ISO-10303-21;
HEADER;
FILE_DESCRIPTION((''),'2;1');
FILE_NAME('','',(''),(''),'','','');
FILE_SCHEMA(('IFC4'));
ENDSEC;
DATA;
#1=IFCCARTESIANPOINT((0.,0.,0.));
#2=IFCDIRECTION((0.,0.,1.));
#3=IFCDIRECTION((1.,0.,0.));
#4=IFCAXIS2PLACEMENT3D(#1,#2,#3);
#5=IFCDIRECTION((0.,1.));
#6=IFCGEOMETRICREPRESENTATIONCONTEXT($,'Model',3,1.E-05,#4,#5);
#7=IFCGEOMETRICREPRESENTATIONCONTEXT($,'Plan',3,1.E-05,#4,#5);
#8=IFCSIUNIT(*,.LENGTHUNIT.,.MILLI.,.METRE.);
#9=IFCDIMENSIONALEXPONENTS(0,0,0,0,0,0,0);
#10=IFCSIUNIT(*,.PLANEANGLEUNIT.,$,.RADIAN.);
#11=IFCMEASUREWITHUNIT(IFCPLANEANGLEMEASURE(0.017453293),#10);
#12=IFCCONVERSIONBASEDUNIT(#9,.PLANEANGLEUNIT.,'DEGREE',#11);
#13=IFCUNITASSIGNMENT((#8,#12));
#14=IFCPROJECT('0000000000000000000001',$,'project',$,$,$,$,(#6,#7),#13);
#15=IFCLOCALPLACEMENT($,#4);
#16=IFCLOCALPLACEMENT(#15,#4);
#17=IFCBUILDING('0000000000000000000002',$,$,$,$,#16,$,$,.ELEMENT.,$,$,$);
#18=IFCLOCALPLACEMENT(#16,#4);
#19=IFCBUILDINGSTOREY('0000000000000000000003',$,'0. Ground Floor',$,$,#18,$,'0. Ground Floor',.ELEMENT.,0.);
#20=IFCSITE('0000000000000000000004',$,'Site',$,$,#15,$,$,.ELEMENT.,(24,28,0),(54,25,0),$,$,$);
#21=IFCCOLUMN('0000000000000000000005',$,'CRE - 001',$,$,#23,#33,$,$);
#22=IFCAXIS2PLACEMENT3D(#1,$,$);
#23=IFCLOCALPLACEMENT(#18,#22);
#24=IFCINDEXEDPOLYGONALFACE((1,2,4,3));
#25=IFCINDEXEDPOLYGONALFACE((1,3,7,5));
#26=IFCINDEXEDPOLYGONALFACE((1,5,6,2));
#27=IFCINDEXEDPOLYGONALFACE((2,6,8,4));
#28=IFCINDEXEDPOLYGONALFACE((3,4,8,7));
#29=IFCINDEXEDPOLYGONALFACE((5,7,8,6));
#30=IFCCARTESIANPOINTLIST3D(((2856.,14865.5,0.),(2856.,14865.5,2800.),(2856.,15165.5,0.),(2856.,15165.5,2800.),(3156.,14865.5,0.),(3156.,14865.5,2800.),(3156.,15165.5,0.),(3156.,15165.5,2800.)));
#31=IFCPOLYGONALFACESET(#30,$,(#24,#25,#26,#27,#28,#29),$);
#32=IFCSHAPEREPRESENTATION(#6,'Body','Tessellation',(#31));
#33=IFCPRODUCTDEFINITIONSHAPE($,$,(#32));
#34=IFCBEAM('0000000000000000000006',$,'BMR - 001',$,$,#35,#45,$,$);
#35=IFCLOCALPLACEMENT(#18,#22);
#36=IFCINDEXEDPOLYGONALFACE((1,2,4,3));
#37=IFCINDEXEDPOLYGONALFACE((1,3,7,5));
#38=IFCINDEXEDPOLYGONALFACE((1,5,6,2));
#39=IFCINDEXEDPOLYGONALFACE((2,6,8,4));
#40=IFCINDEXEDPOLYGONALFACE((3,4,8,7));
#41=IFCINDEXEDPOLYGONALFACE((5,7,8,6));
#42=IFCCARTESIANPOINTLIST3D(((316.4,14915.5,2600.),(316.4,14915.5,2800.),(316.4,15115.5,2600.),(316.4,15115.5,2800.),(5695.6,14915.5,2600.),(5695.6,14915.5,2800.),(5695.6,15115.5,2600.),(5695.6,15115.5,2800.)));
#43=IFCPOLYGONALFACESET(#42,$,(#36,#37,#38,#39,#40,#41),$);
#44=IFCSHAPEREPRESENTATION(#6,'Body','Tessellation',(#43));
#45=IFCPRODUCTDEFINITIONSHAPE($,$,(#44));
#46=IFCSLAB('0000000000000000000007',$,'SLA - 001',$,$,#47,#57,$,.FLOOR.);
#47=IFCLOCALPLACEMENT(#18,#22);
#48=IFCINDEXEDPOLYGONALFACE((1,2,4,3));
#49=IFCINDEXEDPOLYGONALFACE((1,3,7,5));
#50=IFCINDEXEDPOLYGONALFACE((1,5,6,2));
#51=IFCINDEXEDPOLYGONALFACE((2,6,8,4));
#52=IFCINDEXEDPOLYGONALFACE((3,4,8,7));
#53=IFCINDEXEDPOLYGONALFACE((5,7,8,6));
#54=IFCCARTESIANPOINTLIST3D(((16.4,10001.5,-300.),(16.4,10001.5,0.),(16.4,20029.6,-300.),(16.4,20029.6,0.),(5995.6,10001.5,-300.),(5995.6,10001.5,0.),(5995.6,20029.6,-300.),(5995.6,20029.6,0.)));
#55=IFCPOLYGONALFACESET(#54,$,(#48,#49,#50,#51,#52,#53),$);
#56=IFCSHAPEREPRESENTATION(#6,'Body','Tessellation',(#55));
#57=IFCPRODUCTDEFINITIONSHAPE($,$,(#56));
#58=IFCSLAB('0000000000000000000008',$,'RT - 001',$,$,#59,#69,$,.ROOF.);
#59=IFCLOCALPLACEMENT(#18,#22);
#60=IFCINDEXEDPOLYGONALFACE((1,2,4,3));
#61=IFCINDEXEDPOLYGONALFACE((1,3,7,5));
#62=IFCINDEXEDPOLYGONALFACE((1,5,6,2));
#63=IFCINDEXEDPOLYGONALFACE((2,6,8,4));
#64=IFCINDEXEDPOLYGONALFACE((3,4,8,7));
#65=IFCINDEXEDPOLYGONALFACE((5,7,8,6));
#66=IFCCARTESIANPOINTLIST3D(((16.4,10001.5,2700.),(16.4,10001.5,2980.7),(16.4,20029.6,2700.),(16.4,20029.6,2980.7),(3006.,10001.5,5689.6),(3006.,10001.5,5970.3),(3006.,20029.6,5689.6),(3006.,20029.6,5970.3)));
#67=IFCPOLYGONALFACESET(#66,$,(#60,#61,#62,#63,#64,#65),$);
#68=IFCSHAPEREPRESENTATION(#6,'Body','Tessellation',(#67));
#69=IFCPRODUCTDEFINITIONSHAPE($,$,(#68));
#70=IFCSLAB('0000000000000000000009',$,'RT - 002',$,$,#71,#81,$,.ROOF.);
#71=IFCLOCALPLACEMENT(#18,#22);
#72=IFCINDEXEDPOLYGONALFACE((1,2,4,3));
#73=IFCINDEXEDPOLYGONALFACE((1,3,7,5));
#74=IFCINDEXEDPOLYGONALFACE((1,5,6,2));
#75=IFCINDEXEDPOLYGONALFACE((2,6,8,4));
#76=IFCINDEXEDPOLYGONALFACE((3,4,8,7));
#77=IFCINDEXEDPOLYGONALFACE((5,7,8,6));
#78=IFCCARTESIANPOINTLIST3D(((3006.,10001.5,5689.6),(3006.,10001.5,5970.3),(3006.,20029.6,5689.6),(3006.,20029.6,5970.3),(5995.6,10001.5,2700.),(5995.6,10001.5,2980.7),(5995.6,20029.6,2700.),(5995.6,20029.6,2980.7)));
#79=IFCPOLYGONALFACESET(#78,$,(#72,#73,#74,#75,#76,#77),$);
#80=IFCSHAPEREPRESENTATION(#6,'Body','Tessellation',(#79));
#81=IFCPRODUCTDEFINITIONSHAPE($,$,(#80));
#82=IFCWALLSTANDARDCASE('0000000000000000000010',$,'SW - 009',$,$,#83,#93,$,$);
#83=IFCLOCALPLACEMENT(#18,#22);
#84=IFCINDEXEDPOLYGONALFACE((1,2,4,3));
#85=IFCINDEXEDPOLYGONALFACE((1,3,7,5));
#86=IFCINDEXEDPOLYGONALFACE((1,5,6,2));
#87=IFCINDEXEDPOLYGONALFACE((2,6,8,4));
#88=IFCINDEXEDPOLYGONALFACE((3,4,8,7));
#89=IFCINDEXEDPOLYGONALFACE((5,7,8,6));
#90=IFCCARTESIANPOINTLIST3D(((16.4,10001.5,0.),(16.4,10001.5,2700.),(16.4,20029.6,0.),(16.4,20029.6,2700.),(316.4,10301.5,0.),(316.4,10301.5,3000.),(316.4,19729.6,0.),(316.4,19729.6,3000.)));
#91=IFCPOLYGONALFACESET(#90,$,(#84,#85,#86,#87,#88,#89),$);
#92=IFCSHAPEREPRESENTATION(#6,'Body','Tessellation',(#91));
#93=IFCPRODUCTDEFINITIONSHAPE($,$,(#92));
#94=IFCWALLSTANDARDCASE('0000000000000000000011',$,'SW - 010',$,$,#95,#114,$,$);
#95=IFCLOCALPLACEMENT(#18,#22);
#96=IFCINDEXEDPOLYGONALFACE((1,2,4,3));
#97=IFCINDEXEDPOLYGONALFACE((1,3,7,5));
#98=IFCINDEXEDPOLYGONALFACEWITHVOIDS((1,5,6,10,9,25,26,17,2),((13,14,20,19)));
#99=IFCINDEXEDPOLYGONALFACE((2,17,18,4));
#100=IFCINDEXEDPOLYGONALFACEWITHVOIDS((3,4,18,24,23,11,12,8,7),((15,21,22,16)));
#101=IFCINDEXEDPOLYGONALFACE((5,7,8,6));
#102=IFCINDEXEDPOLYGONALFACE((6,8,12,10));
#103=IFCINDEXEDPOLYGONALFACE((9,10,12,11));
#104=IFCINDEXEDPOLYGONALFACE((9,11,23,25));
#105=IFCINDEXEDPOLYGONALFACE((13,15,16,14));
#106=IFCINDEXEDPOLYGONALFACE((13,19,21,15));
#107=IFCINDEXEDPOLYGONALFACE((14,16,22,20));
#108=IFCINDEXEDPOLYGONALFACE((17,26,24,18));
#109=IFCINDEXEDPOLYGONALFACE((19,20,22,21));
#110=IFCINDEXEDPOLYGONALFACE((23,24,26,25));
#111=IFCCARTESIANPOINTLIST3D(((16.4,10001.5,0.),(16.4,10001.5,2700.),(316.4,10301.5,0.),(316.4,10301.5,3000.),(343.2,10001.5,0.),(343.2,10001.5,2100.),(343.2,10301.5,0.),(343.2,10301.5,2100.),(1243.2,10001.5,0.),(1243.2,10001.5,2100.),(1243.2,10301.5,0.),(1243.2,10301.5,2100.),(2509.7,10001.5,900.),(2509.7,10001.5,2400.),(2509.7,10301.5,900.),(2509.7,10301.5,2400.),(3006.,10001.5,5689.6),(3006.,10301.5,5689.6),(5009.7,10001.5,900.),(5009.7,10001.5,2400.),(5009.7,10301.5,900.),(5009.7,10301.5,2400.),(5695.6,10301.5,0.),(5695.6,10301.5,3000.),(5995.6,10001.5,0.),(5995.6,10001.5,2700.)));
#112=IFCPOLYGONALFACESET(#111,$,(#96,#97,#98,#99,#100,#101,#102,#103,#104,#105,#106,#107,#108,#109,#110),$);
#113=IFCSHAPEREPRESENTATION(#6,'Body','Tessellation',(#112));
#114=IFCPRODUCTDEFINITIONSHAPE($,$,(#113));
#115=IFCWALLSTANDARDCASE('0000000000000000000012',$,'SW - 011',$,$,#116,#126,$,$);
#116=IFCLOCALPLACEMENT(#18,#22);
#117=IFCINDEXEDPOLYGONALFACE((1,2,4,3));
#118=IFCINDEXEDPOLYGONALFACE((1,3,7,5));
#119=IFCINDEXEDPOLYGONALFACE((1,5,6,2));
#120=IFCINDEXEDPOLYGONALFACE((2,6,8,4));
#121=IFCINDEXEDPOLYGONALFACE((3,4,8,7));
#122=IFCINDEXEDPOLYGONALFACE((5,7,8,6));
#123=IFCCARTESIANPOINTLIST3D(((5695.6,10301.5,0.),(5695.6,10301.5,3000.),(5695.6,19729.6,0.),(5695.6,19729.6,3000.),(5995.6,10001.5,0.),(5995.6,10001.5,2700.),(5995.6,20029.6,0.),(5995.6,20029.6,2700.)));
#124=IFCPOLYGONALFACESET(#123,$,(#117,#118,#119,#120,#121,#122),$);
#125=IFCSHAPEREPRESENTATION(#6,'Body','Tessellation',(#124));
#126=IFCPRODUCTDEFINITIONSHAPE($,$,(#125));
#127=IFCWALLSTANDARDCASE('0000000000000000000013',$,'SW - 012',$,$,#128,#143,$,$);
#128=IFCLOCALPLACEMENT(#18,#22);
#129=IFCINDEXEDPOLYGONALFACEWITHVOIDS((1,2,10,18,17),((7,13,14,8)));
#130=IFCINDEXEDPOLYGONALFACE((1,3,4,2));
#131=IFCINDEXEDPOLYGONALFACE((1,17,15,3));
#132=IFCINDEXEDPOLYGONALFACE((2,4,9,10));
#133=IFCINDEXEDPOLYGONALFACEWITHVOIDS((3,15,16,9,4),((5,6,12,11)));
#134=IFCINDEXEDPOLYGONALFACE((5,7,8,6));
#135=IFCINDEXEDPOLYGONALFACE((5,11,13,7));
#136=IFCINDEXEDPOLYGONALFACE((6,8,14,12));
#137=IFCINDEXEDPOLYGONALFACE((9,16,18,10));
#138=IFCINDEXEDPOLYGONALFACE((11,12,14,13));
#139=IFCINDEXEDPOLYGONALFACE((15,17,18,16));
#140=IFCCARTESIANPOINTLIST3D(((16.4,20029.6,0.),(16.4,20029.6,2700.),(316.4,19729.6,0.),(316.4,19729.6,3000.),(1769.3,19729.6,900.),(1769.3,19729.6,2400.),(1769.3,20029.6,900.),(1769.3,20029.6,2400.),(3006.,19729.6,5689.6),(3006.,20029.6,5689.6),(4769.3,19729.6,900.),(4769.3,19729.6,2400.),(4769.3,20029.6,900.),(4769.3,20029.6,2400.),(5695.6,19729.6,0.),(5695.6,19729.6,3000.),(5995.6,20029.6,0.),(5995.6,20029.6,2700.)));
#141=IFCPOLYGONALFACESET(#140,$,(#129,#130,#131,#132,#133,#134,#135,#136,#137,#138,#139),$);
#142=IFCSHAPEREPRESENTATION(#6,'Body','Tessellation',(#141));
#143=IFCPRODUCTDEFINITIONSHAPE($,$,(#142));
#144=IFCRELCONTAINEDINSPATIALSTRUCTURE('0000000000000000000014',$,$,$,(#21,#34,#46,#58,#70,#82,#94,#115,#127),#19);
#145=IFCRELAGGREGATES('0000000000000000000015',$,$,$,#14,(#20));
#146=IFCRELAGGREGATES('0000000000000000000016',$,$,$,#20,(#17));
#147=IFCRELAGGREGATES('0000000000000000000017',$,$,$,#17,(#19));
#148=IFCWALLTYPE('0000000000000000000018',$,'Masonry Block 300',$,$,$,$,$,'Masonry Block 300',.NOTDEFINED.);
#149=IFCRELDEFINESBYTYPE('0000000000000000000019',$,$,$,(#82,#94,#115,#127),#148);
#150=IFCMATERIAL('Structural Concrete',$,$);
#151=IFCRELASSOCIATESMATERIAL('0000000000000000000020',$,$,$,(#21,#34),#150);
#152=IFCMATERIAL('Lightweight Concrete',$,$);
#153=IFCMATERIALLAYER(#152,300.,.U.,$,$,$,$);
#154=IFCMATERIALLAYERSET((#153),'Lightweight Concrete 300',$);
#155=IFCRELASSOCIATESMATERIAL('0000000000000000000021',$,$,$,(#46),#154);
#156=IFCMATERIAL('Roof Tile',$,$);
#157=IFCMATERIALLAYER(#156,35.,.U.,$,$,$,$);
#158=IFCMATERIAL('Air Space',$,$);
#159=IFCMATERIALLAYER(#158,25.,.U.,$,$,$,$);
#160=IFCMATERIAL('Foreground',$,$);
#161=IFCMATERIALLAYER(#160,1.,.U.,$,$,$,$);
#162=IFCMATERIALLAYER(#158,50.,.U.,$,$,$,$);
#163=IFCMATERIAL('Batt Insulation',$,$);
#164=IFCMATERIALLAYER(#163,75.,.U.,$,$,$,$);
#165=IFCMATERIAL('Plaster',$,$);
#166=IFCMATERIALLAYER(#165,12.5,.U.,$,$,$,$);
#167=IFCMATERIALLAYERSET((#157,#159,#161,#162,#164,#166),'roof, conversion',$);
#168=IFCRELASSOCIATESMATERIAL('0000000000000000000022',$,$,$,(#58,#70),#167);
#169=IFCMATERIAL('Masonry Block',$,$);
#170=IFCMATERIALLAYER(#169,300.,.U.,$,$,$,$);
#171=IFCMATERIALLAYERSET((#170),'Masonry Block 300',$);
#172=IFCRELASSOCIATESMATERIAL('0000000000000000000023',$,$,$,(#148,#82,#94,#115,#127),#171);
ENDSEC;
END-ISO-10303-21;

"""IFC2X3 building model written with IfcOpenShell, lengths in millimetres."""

from ifc_helpers import new_model, entity, si_unit, converted_unit, direction, frame, frame_2d, origin_with_axes, origin_2d_with_axis, place, context, project, spatial, polyline, rectangle, outline, extrude, clip, halfspace, bounded_halfspace, material, layer, layer_set, layer_usage, type_object, element, save


model = new_model("IFC2X3")

# Units and contexts
model_context = context("Model", 3, precision=1e-05, world=origin_with_axes(), true_north=direction((0.0, 1.0)))
plan_context = context("Plan", 3, precision=1e-05, world=origin_with_axes(), true_north=direction((0.0, 1.0)))
ifc_project = project(units=[si_unit("LENGTHUNIT", "METRE", prefix="MILLI"), converted_unit("PLANEANGLEUNIT", "DEGREE", entity("IfcPlaneAngleMeasure", 0.017453293), si_unit("PLANEANGLEUNIT", "RADIAN"), dimensions=[0, 0, 0, 0, 0, 0, 0])], contexts=[model_context, plan_context])

# Site, building, storey
site_placement = place(None, origin_with_axes())
site = spatial("IfcSite", under=ifc_project, at=site_placement, Name="Site", CompositionType="ELEMENT", RefLatitude=(24, 28, 0), RefLongitude=(54, 25, 0))
building_placement = place(site_placement, origin_with_axes())
building = spatial("IfcBuilding", under=site, at=building_placement, CompositionType="ELEMENT")
storey_placement = place(building_placement, origin_with_axes())
storey = spatial("IfcBuildingStorey", under=building, at=storey_placement, Name="0. Ground Floor", LongName="0. Ground Floor", CompositionType="ELEMENT", Elevation=0.0)

# Column
ifc_material_1 = material(Name="Structural Concrete")
column_placement = place(storey_placement, frame((3006.0, 15015.5, 0.0), z_axis=(0.0, 0.0, 1.0), x_axis=(1.0, 0.0, 0.0)))
element("IfcColumn", 1, at=column_placement, inside=storey, material=ifc_material_1, Name="CRE - 001", context=model_context, shape_type="SweptSolid", body=[
    extrude(rectangle(XDim=300.0, YDim=300.0, at=origin_2d_with_axis()), origin_with_axes(), (0.0, 0.0, 1.0), 2800.0),
])

# Beam
beam_placement = place(storey_placement, frame((316.4, 15015.5, 2800.0), z_axis=(0.0, 0.0, 1.0), x_axis=(0.0, -1.0, 0.0)))
element("IfcBeam", 2, at=beam_placement, inside=storey, material=ifc_material_1, Name="BMR - 001", context=model_context, shape_type="SweptSolid", body=[
    extrude(rectangle(XDim=200.0, YDim=200.0, at=frame_2d((-100.0, 0.0), x_axis=(1.0, 0.0))), frame((0.0, 0.0, 0.0), z_axis=(0.0, 1.0, 0.0), x_axis=(0.0, 0.0, 1.0)), (0.0, 0.0, 1.0), 5379.1),
])

# Slabs
ifc_material_2 = material(Name="Lightweight Concrete")
ifc_layer_1 = layer(ifc_material_2, 300.0, ventilated="UNKNOWN")
ifc_layer_set_1 = layer_set([ifc_layer_1], Name="Lightweight Concrete 300")
ifc_layer_usage_1 = layer_usage(ifc_layer_set_1, "AXIS3", "NEGATIVE", 300.0)
slab_1_placement = place(storey_placement, frame((16.4, 20029.6, -300.0), z_axis=(0.0, 0.0, 1.0), x_axis=(1.0, 0.0, 0.0)))
element("IfcSlab", 3, at=slab_1_placement, inside=storey, material=ifc_layer_usage_1, Name="SLA - 001", PredefinedType="FLOOR", context=model_context, shape_type="SweptSolid", body=[
    extrude(outline(polyline([(0.0, 0.0), (5979.1, 0.0), (5979.1, -10028.0), (0.0, -10028.0), (0.0, 0.0)])), origin_with_axes(), (0.0, 0.0, 1.0), 300.0),
])
ifc_material_3 = material(Name="Roof Tile")
ifc_layer_2 = layer(ifc_material_3, 35.0, ventilated="UNKNOWN")
ifc_material_4 = material(Name="Air Space")
ifc_layer_3 = layer(ifc_material_4, 25.0, ventilated="UNKNOWN")
ifc_material_5 = material(Name="Foreground")
ifc_layer_4 = layer(ifc_material_5, 1.0, ventilated="UNKNOWN")
ifc_layer_5 = layer(ifc_material_4, 50.0, ventilated="UNKNOWN")
ifc_material_6 = material(Name="Batt Insulation")
ifc_layer_6 = layer(ifc_material_6, 75.0, ventilated="UNKNOWN")
ifc_material_7 = material(Name="Plaster")
ifc_layer_7 = layer(ifc_material_7, 12.5, ventilated="UNKNOWN")
ifc_layer_set_2 = layer_set([ifc_layer_2, ifc_layer_3, ifc_layer_4, ifc_layer_5, ifc_layer_6, ifc_layer_7], Name="roof, conversion")
ifc_layer_usage_2 = layer_usage(ifc_layer_set_2, "AXIS3", "NEGATIVE", 198.5)
slab_2_placement = place(storey_placement, frame((16.4, 20029.6, 2700.0), z_axis=(-0.707107, 0.0, 0.707107), x_axis=(0.0, -1.0, 0.0)))
element("IfcSlab", 4, at=slab_2_placement, inside=storey, material=ifc_layer_usage_2, Name="RT - 001", PredefinedType="ROOF", context=model_context, shape_type="SweptSolid", body=[
    extrude(outline(polyline([(0.0, 0.0), (0.0, 4227.9), (10028.0, 4227.9), (10028.0, 0.0), (0.0, 0.0)])), origin_with_axes(), (0.0, 0.707107, 0.707107), 280.7),
])
ifc_layer_usage_3 = layer_usage(ifc_layer_set_2, "AXIS3", "NEGATIVE", 198.5)
slab_3_placement = place(storey_placement, frame((5995.6, 10001.5, 2700.0), z_axis=(0.707107, 0.0, 0.707107), x_axis=(0.0, 1.0, 0.0)))
element("IfcSlab", 5, at=slab_3_placement, inside=storey, material=ifc_layer_usage_3, Name="RT - 002", PredefinedType="ROOF", context=model_context, shape_type="SweptSolid", body=[
    extrude(outline(polyline([(0.0, 0.0), (10028.0, 0.0), (10028.0, 4227.9), (0.0, 4227.9), (0.0, 0.0)])), origin_with_axes(), (0.0, 0.707107, 0.707107), 280.7),
])

# Wall
ifc_material_8 = material(Name="Masonry Block")
ifc_layer_8 = layer(ifc_material_8, 300.0, ventilated="UNKNOWN")
ifc_layer_set_3 = layer_set([ifc_layer_8], Name="Masonry Block 300")
ifc_layer_usage_4 = layer_usage(ifc_layer_set_3, "AXIS2", "POSITIVE", 0.0)
wall_type_1 = type_object("IfcWallType", Name="Masonry Block 300", ElementType="Masonry Block 300", PredefinedType="NOTDEFINED", material=ifc_layer_set_3)
wall_1_placement = place(storey_placement, frame((16.4, 20029.6, 0.0), z_axis=(0.0, 0.0, 1.0), x_axis=(0.0, -1.0, 0.0)))
element("IfcWallStandardCase", 6, at=wall_1_placement, inside=storey, type_object=wall_type_1, material=ifc_layer_usage_4, Name="SW - 009", context=model_context, shape_type="Clipping", body=[
    clip(extrude(outline(polyline([(0.0, 0.0), (10028.0, 0.0), (9728.0, 300.0), (300.0, 300.0), (0.0, 0.0)])), origin_with_axes(), (0.0, 0.0, 1.0), 6000.0), halfspace(frame((0.0, -1350.0, 1350.0), z_axis=(0.0, 0.707107, -0.707107), x_axis=(0.0, 0.707107, 0.707107)), True)),
])

# Wall, openings
ifc_layer_usage_5 = layer_usage(ifc_layer_set_3, "AXIS2", "POSITIVE", 0.0)
wall_2_placement = place(storey_placement, frame((16.4, 10001.5, 0.0), z_axis=(0.0, 0.0, 1.0), x_axis=(1.0, 0.0, 0.0)))
wall_2 = element("IfcWallStandardCase", 7, at=wall_2_placement, inside=storey, type_object=wall_type_1, material=ifc_layer_usage_5, Name="SW - 010", context=model_context, shape_type="Clipping", body=[
    clip(clip(extrude(outline(polyline([(0.0, 0.0), (5979.1, 0.0), (5679.1, 300.0), (300.0, 300.0), (0.0, 0.0)])), origin_with_axes(), (0.0, 0.0, 1.0), 6000.0), bounded_halfspace(frame((-1350.0, 0.0, 1350.0), z_axis=(0.707107, 0.0, -0.707107), x_axis=(0.0, 1.0, 0.0)), True, origin_with_axes(), polyline([(2989.6, -150.0), (2989.6, 450.0), (-10.0, 450.0), (-10.0, -150.0), (2989.6, -150.0)]))), bounded_halfspace(frame((4339.6, 0.0, 4339.6), z_axis=(-0.707107, 0.0, -0.707107), x_axis=(0.0, 1.0, 0.0)), True, origin_with_axes(), polyline([(2989.6, -150.0), (2989.6, 450.0), (5989.1, 450.0), (5989.1, -150.0), (2989.6, -150.0)]))),
])
opening_1_placement = place(wall_2_placement, frame((776.8, 0.0, 0.0), z_axis=(0.0, 0.0, 1.0), x_axis=(1.0, 0.0, 0.0)))
element("IfcOpeningElement", 8, at=opening_1_placement, cuts=wall_2, ObjectType="Opening", context=model_context, shape_type="SweptSolid", body=[
    extrude(rectangle(XDim=900.0, YDim=2100.0, at=frame_2d((0.0, 1050.0), x_axis=(-1.0, 0.0))), frame((0.0, 0.0, 0.0), z_axis=(0.0, 1.0, 0.0), x_axis=(-1.0, 0.0, 0.0)), (0.0, 0.0, 1.0), 300.0),
])
opening_2_placement = place(wall_2_placement, frame((3743.3, 0.0, 900.0), z_axis=(0.0, 0.0, 1.0), x_axis=(1.0, 0.0, 0.0)))
element("IfcOpeningElement", 9, at=opening_2_placement, cuts=wall_2, ObjectType="Opening", context=model_context, shape_type="SweptSolid", body=[
    extrude(rectangle(XDim=2500.0, YDim=1500.0, at=frame_2d((0.0, 750.0), x_axis=(-1.0, 0.0))), frame((0.0, 0.0, 0.0), z_axis=(0.0, 1.0, 0.0), x_axis=(-1.0, 0.0, 0.0)), (0.0, 0.0, 1.0), 300.0),
])

# Wall
ifc_layer_usage_6 = layer_usage(ifc_layer_set_3, "AXIS2", "POSITIVE", 0.0)
wall_3_placement = place(storey_placement, frame((5995.6, 10001.5, 0.0), z_axis=(0.0, 0.0, 1.0), x_axis=(0.0, 1.0, 0.0)))
element("IfcWallStandardCase", 10, at=wall_3_placement, inside=storey, type_object=wall_type_1, material=ifc_layer_usage_6, Name="SW - 011", context=model_context, shape_type="Clipping", body=[
    clip(extrude(outline(polyline([(0.0, 0.0), (10028.0, 0.0), (9728.0, 300.0), (300.0, 300.0), (0.0, 0.0)])), origin_with_axes(), (0.0, 0.0, 1.0), 6000.0), halfspace(frame((0.0, -1350.0, 1350.0), z_axis=(0.0, 0.707107, -0.707107), x_axis=(0.0, 0.707107, 0.707107)), True)),
])

# Wall, opening
ifc_layer_usage_7 = layer_usage(ifc_layer_set_3, "AXIS2", "POSITIVE", 0.0)
wall_4_placement = place(storey_placement, frame((5995.6, 20029.6, 0.0), z_axis=(0.0, 0.0, 1.0), x_axis=(-1.0, 0.0, 0.0)))
wall_4 = element("IfcWallStandardCase", 11, at=wall_4_placement, inside=storey, type_object=wall_type_1, material=ifc_layer_usage_7, Name="SW - 012", context=model_context, shape_type="Clipping", body=[
    clip(clip(extrude(outline(polyline([(0.0, 0.0), (5979.1, 0.0), (5679.1, 300.0), (300.0, 300.0), (0.0, 0.0)])), origin_with_axes(), (0.0, 0.0, 1.0), 6000.0), bounded_halfspace(frame((4339.6, 0.0, 4339.6), z_axis=(-0.707107, 0.0, -0.707107), x_axis=(0.0, 1.0, 0.0)), True, origin_with_axes(), polyline([(2989.6, -150.0), (2989.6, 450.0), (5989.1, 450.0), (5989.1, -150.0), (2989.6, -150.0)]))), bounded_halfspace(frame((-1350.0, 0.0, 1350.0), z_axis=(0.707107, 0.0, -0.707107), x_axis=(0.0, 1.0, 0.0)), True, origin_with_axes(), polyline([(2989.6, -150.0), (2989.6, 450.0), (-10.0, 450.0), (-10.0, -150.0), (2989.6, -150.0)]))),
])
opening_3_placement = place(wall_4_placement, frame((2726.3, 0.0, 900.0), z_axis=(0.0, 0.0, 1.0), x_axis=(1.0, 0.0, 0.0)))
element("IfcOpeningElement", 12, at=opening_3_placement, cuts=wall_4, ObjectType="Opening", context=model_context, shape_type="SweptSolid", body=[
    extrude(rectangle(XDim=3000.0, YDim=1500.0, at=frame_2d((0.0, 750.0), x_axis=(1.0, 0.0))), frame((0.0, 0.0, 0.0), z_axis=(0.0, 1.0, 0.0), x_axis=(-1.0, 0.0, 0.0)), (0.0, 0.0, 1.0), 300.0),
])

save(model, "model.ifc")
